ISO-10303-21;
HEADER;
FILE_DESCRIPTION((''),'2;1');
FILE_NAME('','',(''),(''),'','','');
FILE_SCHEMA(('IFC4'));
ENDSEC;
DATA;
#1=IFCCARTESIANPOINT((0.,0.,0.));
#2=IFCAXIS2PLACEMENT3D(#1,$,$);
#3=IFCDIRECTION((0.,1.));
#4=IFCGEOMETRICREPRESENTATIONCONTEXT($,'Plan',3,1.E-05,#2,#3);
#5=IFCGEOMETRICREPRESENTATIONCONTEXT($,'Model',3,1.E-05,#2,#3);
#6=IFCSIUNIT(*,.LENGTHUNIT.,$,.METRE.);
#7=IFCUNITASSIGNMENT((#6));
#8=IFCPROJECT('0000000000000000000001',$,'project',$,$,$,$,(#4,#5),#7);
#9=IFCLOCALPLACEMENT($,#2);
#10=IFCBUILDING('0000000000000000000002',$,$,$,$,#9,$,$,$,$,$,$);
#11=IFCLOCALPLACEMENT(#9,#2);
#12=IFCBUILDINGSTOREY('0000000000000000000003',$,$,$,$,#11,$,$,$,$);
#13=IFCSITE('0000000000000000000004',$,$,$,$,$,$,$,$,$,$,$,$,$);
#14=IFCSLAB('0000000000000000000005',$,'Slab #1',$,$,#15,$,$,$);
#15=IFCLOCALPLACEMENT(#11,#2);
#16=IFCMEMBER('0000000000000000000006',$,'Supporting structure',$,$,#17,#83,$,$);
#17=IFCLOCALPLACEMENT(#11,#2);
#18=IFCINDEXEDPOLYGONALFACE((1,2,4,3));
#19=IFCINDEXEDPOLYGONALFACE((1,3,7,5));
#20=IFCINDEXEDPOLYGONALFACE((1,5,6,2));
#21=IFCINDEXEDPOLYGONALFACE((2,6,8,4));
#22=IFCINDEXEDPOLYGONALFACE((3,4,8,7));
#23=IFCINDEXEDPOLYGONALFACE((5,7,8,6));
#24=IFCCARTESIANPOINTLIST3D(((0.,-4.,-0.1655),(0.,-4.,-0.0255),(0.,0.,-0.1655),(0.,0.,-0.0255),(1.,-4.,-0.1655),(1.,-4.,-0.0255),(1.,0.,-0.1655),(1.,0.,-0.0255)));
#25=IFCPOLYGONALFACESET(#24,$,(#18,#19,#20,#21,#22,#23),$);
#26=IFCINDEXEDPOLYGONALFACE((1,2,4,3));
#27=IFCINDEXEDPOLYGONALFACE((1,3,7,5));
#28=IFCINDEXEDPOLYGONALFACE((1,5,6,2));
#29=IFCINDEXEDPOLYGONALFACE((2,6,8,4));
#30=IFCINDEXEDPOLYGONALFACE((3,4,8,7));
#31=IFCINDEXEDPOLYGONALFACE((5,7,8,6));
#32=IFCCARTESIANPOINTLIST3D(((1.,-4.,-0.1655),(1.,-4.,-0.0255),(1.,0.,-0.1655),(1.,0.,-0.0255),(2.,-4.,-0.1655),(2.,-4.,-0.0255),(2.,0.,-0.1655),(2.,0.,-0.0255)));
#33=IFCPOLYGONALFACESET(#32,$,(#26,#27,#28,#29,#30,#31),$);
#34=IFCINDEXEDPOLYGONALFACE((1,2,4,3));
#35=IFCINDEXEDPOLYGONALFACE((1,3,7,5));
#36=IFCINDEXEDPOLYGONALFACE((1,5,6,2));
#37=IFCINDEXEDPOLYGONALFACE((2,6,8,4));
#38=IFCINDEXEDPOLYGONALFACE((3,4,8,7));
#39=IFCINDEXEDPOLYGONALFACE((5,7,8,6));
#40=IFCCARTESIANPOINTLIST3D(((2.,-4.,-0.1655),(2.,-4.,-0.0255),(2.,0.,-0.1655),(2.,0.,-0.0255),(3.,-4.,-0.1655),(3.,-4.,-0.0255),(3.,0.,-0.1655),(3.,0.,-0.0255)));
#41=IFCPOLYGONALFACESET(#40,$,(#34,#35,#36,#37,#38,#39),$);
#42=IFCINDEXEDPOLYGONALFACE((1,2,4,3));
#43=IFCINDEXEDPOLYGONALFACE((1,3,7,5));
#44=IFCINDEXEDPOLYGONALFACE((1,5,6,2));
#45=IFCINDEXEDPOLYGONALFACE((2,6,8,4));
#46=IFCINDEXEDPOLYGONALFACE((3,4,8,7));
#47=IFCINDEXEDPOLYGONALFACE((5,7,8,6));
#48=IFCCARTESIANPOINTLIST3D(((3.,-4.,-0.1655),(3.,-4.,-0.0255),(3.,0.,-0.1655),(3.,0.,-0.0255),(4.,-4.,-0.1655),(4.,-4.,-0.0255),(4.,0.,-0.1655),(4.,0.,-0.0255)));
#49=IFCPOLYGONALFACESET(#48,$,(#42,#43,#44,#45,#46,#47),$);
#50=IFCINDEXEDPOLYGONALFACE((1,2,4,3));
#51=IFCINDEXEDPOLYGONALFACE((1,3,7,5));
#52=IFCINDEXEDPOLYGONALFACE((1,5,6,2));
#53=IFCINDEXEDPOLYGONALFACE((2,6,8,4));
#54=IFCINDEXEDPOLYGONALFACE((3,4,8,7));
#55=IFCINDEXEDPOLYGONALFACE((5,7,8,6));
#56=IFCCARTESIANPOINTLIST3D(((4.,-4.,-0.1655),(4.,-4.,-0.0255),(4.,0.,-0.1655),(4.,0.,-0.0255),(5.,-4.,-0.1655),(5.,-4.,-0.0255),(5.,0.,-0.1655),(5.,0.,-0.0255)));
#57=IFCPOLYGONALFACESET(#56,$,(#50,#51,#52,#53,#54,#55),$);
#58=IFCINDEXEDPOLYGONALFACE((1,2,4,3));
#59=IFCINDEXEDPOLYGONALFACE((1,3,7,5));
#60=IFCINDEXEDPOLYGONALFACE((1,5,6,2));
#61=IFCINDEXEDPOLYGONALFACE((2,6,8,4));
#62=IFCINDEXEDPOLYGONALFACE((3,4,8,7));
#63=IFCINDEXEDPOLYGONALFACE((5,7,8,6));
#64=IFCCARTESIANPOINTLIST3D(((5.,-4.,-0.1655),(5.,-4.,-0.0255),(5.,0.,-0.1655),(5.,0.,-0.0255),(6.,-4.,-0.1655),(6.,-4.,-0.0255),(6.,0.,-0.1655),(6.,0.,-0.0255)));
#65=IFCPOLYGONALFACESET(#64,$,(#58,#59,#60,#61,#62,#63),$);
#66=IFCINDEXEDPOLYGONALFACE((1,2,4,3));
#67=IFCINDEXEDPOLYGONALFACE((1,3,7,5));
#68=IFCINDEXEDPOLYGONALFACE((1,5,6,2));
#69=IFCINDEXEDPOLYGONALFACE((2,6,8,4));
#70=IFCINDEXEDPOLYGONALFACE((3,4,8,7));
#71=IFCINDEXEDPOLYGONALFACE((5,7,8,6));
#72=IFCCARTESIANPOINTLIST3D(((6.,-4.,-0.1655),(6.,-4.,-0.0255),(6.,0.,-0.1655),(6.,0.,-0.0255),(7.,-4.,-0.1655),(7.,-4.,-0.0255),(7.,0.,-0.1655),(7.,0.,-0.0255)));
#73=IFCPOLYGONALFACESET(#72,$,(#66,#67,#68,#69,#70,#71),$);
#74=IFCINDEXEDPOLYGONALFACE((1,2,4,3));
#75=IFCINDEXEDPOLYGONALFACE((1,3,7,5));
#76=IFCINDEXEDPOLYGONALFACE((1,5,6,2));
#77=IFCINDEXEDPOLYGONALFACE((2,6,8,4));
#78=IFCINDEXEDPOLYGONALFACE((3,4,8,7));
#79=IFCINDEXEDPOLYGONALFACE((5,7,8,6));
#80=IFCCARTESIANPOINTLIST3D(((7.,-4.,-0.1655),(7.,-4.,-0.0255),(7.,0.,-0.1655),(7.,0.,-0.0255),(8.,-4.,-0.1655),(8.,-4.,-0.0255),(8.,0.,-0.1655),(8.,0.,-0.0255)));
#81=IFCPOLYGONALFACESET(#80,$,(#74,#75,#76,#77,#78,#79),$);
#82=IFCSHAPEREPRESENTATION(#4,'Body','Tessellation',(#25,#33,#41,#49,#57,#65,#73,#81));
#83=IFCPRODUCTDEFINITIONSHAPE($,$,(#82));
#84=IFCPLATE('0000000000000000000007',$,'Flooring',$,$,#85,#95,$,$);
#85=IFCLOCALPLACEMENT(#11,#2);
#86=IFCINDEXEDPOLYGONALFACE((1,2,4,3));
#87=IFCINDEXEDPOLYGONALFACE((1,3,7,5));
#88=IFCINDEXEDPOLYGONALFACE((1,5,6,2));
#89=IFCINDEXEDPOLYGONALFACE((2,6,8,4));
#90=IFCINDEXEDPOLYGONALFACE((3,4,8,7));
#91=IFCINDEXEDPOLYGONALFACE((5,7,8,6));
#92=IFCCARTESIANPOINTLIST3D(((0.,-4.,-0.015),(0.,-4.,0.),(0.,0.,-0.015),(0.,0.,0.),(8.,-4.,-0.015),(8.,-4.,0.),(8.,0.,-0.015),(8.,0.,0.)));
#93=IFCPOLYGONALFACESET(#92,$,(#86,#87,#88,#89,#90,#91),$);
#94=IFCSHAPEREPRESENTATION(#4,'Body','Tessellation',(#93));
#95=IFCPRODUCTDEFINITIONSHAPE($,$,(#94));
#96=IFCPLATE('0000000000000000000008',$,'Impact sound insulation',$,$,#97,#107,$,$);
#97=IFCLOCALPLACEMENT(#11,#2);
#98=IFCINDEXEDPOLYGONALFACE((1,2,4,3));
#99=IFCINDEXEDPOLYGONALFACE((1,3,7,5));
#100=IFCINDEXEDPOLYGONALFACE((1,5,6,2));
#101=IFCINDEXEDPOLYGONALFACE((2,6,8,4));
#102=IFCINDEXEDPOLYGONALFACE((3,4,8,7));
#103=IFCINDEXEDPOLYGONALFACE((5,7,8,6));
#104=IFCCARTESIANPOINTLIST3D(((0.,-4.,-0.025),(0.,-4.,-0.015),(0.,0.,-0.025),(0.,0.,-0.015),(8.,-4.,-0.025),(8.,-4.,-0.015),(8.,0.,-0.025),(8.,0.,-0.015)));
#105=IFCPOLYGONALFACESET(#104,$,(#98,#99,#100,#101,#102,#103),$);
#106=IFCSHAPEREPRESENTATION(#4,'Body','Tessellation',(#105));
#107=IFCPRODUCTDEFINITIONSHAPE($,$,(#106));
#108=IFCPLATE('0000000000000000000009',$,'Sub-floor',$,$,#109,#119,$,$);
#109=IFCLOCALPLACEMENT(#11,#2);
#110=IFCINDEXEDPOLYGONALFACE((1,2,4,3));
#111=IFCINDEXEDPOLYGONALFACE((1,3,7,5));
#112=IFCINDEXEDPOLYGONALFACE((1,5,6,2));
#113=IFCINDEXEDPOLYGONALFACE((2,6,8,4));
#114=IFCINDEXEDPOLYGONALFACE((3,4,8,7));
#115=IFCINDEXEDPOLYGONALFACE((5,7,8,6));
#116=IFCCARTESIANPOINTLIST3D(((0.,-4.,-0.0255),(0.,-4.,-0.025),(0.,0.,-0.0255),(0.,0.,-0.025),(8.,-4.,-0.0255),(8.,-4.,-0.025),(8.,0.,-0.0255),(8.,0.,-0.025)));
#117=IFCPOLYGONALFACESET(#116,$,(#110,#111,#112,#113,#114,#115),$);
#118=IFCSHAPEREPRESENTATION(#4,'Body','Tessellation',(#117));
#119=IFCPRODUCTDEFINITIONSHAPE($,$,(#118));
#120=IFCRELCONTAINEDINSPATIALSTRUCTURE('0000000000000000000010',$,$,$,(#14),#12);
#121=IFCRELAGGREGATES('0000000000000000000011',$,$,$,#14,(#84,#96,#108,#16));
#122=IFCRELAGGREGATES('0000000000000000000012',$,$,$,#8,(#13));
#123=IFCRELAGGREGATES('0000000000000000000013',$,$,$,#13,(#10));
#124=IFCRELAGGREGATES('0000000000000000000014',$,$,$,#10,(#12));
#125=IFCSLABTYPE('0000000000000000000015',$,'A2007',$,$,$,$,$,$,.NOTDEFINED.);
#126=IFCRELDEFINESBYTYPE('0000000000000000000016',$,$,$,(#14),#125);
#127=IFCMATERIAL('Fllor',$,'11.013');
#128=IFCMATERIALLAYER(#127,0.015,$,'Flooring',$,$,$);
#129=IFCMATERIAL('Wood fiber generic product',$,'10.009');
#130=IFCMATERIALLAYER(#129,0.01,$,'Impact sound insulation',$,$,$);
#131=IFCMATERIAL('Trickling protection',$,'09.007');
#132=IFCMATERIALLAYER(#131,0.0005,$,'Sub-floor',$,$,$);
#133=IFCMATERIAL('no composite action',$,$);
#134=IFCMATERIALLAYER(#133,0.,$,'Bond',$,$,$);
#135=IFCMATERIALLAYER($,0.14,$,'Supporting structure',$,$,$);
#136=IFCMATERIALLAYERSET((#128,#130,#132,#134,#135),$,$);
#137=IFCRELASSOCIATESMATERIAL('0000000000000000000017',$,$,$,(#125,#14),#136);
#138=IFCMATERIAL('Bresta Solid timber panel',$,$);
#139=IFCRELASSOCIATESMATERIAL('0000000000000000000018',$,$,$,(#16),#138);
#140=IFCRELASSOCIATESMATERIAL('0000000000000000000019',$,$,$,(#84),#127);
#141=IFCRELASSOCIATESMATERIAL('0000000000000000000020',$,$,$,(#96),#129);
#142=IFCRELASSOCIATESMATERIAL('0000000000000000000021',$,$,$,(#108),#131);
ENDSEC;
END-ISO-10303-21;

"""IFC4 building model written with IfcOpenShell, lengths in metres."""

from ifc_helpers import new_model, si_unit, direction, frame, frame_2d, origin, origin_with_axes, place, context, project, spatial, rectangle, extrude, material, layer, layer_set, type_object, element, aggregate, save


model = new_model("IFC4")

# Units and contexts
plan_context = context("Plan", 3, precision=1e-05, world=origin(), true_north=direction((0.0, 1.0)))
model_context = context("Model", 3, precision=1e-05, world=origin(), true_north=direction((0.0, 1.0)))
ifc_project = project(units=[si_unit("LENGTHUNIT", "METRE")], contexts=[plan_context, model_context])

# Site, building, storey
site = spatial("IfcSite", under=ifc_project)
building_placement = place(None, origin())
building = spatial("IfcBuilding", under=site, at=building_placement)
storey_placement = place(building_placement, origin())
storey = spatial("IfcBuildingStorey", under=building, at=storey_placement)

# Slab, member, plates
ifc_material_1 = material(Name="Fllor", Category="11.013")
ifc_layer_1 = layer(ifc_material_1, 0.015, Name="Flooring")
ifc_material_2 = material(Name="Wood fiber generic product", Category="10.009")
ifc_layer_2 = layer(ifc_material_2, 0.01, Name="Impact sound insulation")
ifc_material_3 = material(Name="Trickling protection", Category="09.007")
ifc_layer_3 = layer(ifc_material_3, 0.0005, Name="Sub-floor")
ifc_material_4 = material(Name="no composite action")
ifc_layer_4 = layer(ifc_material_4, 0.0, Name="Bond")
ifc_layer_5 = layer(None, 0.14, Name="Supporting structure")
ifc_layer_set = layer_set([ifc_layer_1, ifc_layer_2, ifc_layer_3, ifc_layer_4, ifc_layer_5])
slab_type = type_object("IfcSlabType", Name="A2007", PredefinedType="NOTDEFINED", material=ifc_layer_set)
slab_placement = place(None, frame((0.0, 0.0, 0.0), z_axis=(0.0, 0.0, -1.0), x_axis=(1.0, 0.0, 0.0)))
slab = element("IfcSlab", 1, at=slab_placement, inside=storey, type_object=slab_type, material=ifc_layer_set, Name="Slab #1")
ifc_material_5 = material(Name="Bresta Solid timber panel")
member_placement = place(slab_placement, origin())
member = element("IfcMember", 2, at=member_placement, material=ifc_material_5, Name="Supporting structure", context=plan_context, shape_type="SweptSolid", body=[
    extrude(rectangle(XDim=1.0, YDim=0.14, at=frame_2d((0.5, 0.07), x_axis=(1.0, 0.0))), frame((0.0, 4.0, 0.0255), z_axis=(0.0, -1.0, 0.0), x_axis=(1.0, 0.0, 0.0)), (0.0, 0.0, 1.0), 4.0),
    extrude(rectangle(XDim=1.0, YDim=0.14, at=frame_2d((0.5, 0.07), x_axis=(1.0, 0.0))), frame((1.0, 4.0, 0.0255), z_axis=(0.0, -1.0, 0.0), x_axis=(1.0, 0.0, 0.0)), (0.0, 0.0, 1.0), 4.0),
    extrude(rectangle(XDim=1.0, YDim=0.14, at=frame_2d((0.5, 0.07), x_axis=(1.0, 0.0))), frame((2.0, 4.0, 0.0255), z_axis=(0.0, -1.0, 0.0), x_axis=(1.0, 0.0, 0.0)), (0.0, 0.0, 1.0), 4.0),
    extrude(rectangle(XDim=1.0, YDim=0.14, at=frame_2d((0.5, 0.07), x_axis=(1.0, 0.0))), frame((3.0, 4.0, 0.0255), z_axis=(0.0, -1.0, 0.0), x_axis=(1.0, 0.0, 0.0)), (0.0, 0.0, 1.0), 4.0),
    extrude(rectangle(XDim=1.0, YDim=0.14, at=frame_2d((0.5, 0.07), x_axis=(1.0, 0.0))), frame((4.0, 4.0, 0.0255), z_axis=(0.0, -1.0, 0.0), x_axis=(1.0, 0.0, 0.0)), (0.0, 0.0, 1.0), 4.0),
    extrude(rectangle(XDim=1.0, YDim=0.14, at=frame_2d((0.5, 0.07), x_axis=(1.0, 0.0))), frame((5.0, 4.0, 0.0255), z_axis=(0.0, -1.0, 0.0), x_axis=(1.0, 0.0, 0.0)), (0.0, 0.0, 1.0), 4.0),
    extrude(rectangle(XDim=1.0, YDim=0.14, at=frame_2d((0.5, 0.07), x_axis=(1.0, 0.0))), frame((6.0, 4.0, 0.0255), z_axis=(0.0, -1.0, 0.0), x_axis=(1.0, 0.0, 0.0)), (0.0, 0.0, 1.0), 4.0),
    extrude(rectangle(XDim=1.0, YDim=0.14, at=frame_2d((0.5, 0.07), x_axis=(1.0, 0.0))), frame((7.0, 4.0, 0.0255), z_axis=(0.0, -1.0, 0.0), x_axis=(1.0, 0.0, 0.0)), (0.0, 0.0, 1.0), 4.0),
])
plate_1_placement = place(slab_placement, origin())
plate_1 = element("IfcPlate", 3, at=plate_1_placement, material=ifc_material_1, Name="Flooring", context=plan_context, shape_type="SweptSolid", body=[
    extrude(rectangle(XDim=8.0, YDim=4.0, at=frame_2d((4.0, 2.0), x_axis=(1.0, 0.0))), origin_with_axes(), (0.0, 0.0, 1.0), 0.015),
])
plate_2_placement = place(slab_placement, origin())
plate_2 = element("IfcPlate", 4, at=plate_2_placement, material=ifc_material_2, Name="Impact sound insulation", context=plan_context, shape_type="SweptSolid", body=[
    extrude(rectangle(XDim=8.0, YDim=4.0, at=frame_2d((4.0, 2.0), x_axis=(1.0, 0.0))), frame((0.0, 0.0, 0.015), z_axis=(0.0, 0.0, 1.0), x_axis=(1.0, 0.0, 0.0)), (0.0, 0.0, 1.0), 0.01),
])
plate_3_placement = place(slab_placement, origin())
plate_3 = element("IfcPlate", 5, at=plate_3_placement, material=ifc_material_3, Name="Sub-floor", context=plan_context, shape_type="SweptSolid", body=[
    extrude(rectangle(XDim=8.0, YDim=4.0, at=frame_2d((4.0, 2.0), x_axis=(1.0, 0.0))), frame((0.0, 0.0, 0.025), z_axis=(0.0, 0.0, 1.0), x_axis=(1.0, 0.0, 0.0)), (0.0, 0.0, 1.0), 0.0005),
])
aggregate(slab, [plate_1, plate_2, plate_3, member])

save(model, "model.ifc")
